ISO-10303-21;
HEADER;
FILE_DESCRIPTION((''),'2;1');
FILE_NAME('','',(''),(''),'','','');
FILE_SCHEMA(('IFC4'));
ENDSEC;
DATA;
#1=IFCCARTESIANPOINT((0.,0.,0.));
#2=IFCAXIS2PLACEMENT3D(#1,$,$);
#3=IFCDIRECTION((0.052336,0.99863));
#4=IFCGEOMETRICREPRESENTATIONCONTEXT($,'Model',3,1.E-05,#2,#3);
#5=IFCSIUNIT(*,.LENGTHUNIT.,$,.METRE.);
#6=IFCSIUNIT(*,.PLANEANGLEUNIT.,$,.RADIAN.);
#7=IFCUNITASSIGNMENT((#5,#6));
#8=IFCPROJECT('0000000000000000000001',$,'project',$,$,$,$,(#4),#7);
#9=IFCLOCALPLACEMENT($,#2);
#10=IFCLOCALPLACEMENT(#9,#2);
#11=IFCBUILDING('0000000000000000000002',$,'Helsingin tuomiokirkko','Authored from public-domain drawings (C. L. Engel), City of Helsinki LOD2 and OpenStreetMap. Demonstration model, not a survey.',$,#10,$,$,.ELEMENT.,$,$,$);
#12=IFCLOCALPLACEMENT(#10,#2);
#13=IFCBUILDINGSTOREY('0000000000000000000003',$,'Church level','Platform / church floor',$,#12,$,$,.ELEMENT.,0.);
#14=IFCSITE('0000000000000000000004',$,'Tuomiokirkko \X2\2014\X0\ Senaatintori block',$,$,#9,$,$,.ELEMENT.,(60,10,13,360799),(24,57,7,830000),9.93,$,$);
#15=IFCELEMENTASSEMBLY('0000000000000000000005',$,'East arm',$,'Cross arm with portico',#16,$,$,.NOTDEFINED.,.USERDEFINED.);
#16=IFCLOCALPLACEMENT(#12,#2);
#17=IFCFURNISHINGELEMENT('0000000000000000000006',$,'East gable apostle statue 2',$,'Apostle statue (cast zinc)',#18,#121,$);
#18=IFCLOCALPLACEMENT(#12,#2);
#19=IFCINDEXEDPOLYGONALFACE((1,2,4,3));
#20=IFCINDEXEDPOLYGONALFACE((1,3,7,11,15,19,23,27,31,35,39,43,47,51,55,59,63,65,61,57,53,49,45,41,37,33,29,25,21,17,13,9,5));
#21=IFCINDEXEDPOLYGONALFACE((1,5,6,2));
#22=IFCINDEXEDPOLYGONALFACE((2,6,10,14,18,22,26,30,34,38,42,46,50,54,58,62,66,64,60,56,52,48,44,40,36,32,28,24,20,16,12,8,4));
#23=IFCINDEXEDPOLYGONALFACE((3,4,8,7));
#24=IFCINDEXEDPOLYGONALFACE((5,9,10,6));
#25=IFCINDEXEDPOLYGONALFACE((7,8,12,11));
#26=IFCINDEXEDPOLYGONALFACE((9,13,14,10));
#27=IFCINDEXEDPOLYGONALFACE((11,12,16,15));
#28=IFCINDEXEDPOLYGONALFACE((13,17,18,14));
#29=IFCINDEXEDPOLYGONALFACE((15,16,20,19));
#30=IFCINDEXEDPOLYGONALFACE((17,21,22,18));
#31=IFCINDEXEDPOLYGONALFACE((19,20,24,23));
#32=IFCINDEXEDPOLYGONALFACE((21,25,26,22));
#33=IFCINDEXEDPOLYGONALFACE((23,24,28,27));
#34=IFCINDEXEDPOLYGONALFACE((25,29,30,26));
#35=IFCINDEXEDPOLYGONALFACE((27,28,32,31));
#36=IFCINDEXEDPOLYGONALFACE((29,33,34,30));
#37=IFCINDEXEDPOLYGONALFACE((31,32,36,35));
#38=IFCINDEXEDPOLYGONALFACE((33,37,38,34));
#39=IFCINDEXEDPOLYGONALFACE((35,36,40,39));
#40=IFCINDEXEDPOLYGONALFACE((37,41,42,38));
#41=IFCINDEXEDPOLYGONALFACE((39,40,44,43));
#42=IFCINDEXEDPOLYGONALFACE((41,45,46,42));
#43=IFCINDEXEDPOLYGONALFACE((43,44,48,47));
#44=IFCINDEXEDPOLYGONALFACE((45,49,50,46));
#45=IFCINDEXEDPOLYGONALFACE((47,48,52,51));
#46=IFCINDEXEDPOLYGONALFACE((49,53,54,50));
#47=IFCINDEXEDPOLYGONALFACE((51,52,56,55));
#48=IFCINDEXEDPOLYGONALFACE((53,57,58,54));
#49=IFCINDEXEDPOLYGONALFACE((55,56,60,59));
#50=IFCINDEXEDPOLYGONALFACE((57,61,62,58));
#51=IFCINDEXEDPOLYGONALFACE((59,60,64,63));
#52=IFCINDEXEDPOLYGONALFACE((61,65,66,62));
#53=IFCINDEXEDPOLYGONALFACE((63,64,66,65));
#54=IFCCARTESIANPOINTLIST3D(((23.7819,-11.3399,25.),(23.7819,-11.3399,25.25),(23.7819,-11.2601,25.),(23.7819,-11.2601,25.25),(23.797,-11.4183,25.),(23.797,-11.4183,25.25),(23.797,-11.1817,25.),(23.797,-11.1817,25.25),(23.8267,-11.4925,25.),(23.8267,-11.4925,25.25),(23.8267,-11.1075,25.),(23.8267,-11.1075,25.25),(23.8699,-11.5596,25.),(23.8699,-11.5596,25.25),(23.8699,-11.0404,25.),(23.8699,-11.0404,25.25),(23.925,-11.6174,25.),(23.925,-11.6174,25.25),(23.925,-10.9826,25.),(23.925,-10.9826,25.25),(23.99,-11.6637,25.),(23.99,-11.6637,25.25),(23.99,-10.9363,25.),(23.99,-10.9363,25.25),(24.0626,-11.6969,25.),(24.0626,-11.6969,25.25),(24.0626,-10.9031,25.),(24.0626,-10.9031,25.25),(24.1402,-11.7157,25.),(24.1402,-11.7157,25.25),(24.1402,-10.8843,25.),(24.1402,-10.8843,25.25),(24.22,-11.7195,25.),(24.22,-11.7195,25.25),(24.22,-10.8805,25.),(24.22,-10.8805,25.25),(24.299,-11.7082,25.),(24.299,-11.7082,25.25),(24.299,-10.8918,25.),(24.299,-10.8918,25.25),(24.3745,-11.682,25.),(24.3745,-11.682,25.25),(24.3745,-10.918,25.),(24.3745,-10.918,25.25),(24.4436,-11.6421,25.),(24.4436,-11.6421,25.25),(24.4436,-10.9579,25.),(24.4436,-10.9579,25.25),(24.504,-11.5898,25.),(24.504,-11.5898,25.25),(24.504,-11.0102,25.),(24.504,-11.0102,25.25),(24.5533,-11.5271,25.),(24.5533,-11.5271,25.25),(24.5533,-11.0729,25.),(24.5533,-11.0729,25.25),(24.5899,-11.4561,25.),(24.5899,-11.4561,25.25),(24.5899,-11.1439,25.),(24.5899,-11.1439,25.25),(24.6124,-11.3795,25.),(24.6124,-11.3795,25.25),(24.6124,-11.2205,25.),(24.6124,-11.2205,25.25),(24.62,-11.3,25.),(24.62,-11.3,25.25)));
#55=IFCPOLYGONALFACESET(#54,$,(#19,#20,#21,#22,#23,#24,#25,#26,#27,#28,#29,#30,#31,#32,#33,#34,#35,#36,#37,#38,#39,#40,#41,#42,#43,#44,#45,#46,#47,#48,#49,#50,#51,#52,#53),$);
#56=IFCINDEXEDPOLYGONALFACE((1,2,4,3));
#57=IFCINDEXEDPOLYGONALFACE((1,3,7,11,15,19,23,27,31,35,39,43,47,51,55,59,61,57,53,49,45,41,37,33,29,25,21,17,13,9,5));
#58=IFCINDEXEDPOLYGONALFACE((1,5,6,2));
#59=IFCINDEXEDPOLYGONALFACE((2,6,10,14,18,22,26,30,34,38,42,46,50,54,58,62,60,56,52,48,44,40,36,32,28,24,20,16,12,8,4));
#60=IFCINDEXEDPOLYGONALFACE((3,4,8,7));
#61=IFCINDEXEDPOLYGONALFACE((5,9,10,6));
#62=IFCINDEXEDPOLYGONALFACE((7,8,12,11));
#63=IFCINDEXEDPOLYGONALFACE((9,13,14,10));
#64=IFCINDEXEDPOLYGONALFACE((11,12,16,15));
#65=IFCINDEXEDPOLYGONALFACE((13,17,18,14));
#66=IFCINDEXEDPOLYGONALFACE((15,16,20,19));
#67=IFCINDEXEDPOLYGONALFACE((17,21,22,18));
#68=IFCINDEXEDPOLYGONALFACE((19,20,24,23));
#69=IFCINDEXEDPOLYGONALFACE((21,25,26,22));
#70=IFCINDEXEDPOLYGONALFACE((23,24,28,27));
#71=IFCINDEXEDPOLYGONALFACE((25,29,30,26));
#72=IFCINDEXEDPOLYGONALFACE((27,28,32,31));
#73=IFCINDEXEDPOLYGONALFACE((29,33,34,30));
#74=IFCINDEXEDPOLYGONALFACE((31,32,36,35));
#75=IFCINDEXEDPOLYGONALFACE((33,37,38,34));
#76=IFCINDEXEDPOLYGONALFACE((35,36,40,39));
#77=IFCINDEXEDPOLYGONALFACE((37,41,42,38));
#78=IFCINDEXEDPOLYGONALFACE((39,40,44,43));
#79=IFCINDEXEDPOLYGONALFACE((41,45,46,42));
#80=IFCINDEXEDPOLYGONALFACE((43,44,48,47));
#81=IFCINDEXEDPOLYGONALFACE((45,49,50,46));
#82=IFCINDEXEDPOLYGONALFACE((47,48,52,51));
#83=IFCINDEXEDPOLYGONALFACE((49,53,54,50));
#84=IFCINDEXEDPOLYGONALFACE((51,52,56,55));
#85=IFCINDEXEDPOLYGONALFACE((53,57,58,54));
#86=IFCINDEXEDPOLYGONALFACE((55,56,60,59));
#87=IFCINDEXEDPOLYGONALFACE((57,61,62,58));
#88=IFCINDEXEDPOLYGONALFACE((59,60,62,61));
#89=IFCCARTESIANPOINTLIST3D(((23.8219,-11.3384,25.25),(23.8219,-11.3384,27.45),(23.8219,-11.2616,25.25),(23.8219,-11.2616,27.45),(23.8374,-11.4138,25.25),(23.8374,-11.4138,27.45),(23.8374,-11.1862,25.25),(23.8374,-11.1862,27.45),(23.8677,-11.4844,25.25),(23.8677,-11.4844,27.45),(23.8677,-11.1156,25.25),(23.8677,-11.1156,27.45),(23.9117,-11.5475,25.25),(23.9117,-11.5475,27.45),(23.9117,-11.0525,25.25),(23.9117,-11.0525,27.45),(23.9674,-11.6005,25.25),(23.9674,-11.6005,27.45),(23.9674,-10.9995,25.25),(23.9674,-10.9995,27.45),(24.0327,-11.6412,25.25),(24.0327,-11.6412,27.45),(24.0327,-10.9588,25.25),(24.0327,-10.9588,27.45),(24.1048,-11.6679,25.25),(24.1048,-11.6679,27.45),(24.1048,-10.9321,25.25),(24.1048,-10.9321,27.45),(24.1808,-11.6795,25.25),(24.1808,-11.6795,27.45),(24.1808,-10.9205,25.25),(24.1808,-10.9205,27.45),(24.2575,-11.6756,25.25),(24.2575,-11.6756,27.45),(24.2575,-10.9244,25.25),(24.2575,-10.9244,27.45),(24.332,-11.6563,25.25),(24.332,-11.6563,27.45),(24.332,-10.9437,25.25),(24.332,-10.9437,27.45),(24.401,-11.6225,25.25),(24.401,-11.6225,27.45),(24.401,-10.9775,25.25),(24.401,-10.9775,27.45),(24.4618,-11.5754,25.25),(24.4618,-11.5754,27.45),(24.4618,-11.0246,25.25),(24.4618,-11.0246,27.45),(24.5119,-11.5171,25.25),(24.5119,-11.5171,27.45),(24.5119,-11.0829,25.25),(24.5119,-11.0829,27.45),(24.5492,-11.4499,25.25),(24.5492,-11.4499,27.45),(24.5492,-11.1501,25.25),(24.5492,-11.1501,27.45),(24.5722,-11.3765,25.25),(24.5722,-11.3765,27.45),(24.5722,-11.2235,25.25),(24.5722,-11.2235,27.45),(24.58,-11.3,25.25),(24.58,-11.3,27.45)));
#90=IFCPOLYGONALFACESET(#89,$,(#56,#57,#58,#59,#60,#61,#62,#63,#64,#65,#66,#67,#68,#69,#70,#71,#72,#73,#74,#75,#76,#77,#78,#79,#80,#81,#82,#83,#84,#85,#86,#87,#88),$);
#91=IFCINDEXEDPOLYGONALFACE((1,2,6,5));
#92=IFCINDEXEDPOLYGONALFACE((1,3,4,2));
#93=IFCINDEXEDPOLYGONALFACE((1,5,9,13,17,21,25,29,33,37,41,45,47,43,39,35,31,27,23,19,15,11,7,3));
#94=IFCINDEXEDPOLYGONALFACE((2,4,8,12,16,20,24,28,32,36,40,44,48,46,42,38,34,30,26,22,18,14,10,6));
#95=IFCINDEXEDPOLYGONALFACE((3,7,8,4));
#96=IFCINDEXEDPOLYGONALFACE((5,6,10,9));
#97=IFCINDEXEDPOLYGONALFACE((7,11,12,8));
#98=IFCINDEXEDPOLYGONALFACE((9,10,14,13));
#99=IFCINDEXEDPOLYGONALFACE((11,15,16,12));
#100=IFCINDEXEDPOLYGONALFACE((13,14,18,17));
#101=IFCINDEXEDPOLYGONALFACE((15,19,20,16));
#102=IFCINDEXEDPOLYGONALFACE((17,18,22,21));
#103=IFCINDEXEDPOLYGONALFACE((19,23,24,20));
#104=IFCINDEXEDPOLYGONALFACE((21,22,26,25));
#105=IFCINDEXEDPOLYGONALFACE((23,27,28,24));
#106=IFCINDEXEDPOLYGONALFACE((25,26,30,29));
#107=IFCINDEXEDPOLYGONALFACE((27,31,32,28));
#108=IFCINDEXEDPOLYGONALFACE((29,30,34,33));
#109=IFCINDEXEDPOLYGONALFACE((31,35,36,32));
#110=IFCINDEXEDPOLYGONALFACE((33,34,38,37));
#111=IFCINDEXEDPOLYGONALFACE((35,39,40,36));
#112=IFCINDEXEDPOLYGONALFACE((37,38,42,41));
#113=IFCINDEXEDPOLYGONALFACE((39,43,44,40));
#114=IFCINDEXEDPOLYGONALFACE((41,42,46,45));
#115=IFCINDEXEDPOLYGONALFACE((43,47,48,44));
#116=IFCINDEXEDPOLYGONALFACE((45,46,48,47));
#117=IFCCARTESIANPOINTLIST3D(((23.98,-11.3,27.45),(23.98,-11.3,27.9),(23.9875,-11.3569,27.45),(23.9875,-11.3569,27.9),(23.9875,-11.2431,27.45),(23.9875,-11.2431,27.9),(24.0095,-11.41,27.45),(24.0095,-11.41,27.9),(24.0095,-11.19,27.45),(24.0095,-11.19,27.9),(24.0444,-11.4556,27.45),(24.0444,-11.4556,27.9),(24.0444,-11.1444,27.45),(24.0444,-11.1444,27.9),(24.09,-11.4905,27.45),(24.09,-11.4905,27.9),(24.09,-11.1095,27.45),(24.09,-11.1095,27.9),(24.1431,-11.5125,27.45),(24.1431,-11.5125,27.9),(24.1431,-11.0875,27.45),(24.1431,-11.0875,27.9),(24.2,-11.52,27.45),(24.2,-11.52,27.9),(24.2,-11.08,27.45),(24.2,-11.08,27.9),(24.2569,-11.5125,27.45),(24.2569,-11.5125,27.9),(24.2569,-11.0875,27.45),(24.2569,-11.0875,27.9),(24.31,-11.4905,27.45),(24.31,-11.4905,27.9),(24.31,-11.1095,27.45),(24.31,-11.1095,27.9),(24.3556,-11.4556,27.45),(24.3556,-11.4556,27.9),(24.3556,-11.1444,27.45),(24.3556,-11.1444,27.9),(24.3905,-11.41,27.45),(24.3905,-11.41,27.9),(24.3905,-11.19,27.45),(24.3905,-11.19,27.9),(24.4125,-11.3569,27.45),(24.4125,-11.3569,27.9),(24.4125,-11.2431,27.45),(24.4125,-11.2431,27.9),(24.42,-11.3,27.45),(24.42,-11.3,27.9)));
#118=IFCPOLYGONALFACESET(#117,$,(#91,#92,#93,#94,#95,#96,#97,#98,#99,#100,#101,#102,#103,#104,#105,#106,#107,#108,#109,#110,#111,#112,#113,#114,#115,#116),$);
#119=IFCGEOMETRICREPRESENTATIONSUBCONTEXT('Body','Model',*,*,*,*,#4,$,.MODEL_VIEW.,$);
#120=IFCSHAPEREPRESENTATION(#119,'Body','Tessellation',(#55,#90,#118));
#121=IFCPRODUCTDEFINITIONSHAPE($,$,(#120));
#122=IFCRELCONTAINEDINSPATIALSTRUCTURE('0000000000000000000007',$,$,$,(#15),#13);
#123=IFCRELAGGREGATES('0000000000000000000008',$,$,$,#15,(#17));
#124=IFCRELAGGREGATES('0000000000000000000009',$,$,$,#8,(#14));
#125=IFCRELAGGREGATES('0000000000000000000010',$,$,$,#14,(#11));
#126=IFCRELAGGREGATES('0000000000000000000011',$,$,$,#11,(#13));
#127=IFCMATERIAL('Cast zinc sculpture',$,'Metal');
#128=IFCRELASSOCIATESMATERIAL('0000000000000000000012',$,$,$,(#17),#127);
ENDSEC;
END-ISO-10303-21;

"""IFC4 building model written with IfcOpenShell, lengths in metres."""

from ifc_helpers import new_model, si_unit, direction, frame, origin, origin_2d_with_axis, place, context, subcontext, project, spatial, circle, extrude, material, element, aggregate, save


model = new_model("IFC4")

# Units and contexts
model_context = context("Model", 3, precision=1e-05, world=origin(), true_north=direction((0.052336, 0.99863)))
body_context = subcontext(model_context, "Body", "Model", "MODEL_VIEW")
ifc_project = project(units=[si_unit("LENGTHUNIT", "METRE"), si_unit("PLANEANGLEUNIT", "RADIAN")], contexts=[model_context])

# Site, building, storey
site_placement = place(None, origin())
site = spatial("IfcSite", under=ifc_project, at=site_placement, Name="Tuomiokirkko — Senaatintori block", CompositionType="ELEMENT", RefLatitude=(60, 10, 13, 360799), RefLongitude=(24, 57, 7, 830000), RefElevation=9.93)
building_placement = place(site_placement, origin())
building = spatial("IfcBuilding", under=site, at=building_placement, Name="Helsingin tuomiokirkko", Description="Authored from public-domain drawings (C. L. Engel), City of Helsinki LOD2 and OpenStreetMap. Demonstration model, not a survey.", CompositionType="ELEMENT")
storey_placement = place(building_placement, origin())
storey = spatial("IfcBuildingStorey", under=building, at=storey_placement, Name="Church level", Description="Platform / church floor", CompositionType="ELEMENT", Elevation=0.0)

# Element assembly
assembly_1_placement = place(building_placement, origin())
assembly_1 = element("IfcElementAssembly", 1, at=assembly_1_placement, inside=storey, Name="East arm", ObjectType="Cross arm with portico", AssemblyPlace="NOTDEFINED", PredefinedType="USERDEFINED")

# Furnishing element
ifc_material_1 = material(Name="Cast zinc sculpture", Category="Metal")
furnishing_1_placement = place(building_placement, origin())
furnishing_1 = element("IfcFurnishingElement", 2, at=furnishing_1_placement, material=ifc_material_1, Name="East gable apostle statue 2", ObjectType="Apostle statue (cast zinc)", context=body_context, shape_type="SweptSolid", body=[
    extrude(circle(Radius=0.42, at=origin_2d_with_axis()), frame((24.2, -11.3, 25.0)), (0.0, 0.0, 1.0), 0.25),
    extrude(circle(Radius=0.38, at=origin_2d_with_axis()), frame((24.2, -11.3, 25.25)), (0.0, 0.0, 1.0), 2.2),
    extrude(circle(Radius=0.22, at=origin_2d_with_axis()), frame((24.2, -11.3, 27.45)), (0.0, 0.0, 1.0), 0.45),
])
aggregate(assembly_1, [furnishing_1])

save(model, "model.ifc")
